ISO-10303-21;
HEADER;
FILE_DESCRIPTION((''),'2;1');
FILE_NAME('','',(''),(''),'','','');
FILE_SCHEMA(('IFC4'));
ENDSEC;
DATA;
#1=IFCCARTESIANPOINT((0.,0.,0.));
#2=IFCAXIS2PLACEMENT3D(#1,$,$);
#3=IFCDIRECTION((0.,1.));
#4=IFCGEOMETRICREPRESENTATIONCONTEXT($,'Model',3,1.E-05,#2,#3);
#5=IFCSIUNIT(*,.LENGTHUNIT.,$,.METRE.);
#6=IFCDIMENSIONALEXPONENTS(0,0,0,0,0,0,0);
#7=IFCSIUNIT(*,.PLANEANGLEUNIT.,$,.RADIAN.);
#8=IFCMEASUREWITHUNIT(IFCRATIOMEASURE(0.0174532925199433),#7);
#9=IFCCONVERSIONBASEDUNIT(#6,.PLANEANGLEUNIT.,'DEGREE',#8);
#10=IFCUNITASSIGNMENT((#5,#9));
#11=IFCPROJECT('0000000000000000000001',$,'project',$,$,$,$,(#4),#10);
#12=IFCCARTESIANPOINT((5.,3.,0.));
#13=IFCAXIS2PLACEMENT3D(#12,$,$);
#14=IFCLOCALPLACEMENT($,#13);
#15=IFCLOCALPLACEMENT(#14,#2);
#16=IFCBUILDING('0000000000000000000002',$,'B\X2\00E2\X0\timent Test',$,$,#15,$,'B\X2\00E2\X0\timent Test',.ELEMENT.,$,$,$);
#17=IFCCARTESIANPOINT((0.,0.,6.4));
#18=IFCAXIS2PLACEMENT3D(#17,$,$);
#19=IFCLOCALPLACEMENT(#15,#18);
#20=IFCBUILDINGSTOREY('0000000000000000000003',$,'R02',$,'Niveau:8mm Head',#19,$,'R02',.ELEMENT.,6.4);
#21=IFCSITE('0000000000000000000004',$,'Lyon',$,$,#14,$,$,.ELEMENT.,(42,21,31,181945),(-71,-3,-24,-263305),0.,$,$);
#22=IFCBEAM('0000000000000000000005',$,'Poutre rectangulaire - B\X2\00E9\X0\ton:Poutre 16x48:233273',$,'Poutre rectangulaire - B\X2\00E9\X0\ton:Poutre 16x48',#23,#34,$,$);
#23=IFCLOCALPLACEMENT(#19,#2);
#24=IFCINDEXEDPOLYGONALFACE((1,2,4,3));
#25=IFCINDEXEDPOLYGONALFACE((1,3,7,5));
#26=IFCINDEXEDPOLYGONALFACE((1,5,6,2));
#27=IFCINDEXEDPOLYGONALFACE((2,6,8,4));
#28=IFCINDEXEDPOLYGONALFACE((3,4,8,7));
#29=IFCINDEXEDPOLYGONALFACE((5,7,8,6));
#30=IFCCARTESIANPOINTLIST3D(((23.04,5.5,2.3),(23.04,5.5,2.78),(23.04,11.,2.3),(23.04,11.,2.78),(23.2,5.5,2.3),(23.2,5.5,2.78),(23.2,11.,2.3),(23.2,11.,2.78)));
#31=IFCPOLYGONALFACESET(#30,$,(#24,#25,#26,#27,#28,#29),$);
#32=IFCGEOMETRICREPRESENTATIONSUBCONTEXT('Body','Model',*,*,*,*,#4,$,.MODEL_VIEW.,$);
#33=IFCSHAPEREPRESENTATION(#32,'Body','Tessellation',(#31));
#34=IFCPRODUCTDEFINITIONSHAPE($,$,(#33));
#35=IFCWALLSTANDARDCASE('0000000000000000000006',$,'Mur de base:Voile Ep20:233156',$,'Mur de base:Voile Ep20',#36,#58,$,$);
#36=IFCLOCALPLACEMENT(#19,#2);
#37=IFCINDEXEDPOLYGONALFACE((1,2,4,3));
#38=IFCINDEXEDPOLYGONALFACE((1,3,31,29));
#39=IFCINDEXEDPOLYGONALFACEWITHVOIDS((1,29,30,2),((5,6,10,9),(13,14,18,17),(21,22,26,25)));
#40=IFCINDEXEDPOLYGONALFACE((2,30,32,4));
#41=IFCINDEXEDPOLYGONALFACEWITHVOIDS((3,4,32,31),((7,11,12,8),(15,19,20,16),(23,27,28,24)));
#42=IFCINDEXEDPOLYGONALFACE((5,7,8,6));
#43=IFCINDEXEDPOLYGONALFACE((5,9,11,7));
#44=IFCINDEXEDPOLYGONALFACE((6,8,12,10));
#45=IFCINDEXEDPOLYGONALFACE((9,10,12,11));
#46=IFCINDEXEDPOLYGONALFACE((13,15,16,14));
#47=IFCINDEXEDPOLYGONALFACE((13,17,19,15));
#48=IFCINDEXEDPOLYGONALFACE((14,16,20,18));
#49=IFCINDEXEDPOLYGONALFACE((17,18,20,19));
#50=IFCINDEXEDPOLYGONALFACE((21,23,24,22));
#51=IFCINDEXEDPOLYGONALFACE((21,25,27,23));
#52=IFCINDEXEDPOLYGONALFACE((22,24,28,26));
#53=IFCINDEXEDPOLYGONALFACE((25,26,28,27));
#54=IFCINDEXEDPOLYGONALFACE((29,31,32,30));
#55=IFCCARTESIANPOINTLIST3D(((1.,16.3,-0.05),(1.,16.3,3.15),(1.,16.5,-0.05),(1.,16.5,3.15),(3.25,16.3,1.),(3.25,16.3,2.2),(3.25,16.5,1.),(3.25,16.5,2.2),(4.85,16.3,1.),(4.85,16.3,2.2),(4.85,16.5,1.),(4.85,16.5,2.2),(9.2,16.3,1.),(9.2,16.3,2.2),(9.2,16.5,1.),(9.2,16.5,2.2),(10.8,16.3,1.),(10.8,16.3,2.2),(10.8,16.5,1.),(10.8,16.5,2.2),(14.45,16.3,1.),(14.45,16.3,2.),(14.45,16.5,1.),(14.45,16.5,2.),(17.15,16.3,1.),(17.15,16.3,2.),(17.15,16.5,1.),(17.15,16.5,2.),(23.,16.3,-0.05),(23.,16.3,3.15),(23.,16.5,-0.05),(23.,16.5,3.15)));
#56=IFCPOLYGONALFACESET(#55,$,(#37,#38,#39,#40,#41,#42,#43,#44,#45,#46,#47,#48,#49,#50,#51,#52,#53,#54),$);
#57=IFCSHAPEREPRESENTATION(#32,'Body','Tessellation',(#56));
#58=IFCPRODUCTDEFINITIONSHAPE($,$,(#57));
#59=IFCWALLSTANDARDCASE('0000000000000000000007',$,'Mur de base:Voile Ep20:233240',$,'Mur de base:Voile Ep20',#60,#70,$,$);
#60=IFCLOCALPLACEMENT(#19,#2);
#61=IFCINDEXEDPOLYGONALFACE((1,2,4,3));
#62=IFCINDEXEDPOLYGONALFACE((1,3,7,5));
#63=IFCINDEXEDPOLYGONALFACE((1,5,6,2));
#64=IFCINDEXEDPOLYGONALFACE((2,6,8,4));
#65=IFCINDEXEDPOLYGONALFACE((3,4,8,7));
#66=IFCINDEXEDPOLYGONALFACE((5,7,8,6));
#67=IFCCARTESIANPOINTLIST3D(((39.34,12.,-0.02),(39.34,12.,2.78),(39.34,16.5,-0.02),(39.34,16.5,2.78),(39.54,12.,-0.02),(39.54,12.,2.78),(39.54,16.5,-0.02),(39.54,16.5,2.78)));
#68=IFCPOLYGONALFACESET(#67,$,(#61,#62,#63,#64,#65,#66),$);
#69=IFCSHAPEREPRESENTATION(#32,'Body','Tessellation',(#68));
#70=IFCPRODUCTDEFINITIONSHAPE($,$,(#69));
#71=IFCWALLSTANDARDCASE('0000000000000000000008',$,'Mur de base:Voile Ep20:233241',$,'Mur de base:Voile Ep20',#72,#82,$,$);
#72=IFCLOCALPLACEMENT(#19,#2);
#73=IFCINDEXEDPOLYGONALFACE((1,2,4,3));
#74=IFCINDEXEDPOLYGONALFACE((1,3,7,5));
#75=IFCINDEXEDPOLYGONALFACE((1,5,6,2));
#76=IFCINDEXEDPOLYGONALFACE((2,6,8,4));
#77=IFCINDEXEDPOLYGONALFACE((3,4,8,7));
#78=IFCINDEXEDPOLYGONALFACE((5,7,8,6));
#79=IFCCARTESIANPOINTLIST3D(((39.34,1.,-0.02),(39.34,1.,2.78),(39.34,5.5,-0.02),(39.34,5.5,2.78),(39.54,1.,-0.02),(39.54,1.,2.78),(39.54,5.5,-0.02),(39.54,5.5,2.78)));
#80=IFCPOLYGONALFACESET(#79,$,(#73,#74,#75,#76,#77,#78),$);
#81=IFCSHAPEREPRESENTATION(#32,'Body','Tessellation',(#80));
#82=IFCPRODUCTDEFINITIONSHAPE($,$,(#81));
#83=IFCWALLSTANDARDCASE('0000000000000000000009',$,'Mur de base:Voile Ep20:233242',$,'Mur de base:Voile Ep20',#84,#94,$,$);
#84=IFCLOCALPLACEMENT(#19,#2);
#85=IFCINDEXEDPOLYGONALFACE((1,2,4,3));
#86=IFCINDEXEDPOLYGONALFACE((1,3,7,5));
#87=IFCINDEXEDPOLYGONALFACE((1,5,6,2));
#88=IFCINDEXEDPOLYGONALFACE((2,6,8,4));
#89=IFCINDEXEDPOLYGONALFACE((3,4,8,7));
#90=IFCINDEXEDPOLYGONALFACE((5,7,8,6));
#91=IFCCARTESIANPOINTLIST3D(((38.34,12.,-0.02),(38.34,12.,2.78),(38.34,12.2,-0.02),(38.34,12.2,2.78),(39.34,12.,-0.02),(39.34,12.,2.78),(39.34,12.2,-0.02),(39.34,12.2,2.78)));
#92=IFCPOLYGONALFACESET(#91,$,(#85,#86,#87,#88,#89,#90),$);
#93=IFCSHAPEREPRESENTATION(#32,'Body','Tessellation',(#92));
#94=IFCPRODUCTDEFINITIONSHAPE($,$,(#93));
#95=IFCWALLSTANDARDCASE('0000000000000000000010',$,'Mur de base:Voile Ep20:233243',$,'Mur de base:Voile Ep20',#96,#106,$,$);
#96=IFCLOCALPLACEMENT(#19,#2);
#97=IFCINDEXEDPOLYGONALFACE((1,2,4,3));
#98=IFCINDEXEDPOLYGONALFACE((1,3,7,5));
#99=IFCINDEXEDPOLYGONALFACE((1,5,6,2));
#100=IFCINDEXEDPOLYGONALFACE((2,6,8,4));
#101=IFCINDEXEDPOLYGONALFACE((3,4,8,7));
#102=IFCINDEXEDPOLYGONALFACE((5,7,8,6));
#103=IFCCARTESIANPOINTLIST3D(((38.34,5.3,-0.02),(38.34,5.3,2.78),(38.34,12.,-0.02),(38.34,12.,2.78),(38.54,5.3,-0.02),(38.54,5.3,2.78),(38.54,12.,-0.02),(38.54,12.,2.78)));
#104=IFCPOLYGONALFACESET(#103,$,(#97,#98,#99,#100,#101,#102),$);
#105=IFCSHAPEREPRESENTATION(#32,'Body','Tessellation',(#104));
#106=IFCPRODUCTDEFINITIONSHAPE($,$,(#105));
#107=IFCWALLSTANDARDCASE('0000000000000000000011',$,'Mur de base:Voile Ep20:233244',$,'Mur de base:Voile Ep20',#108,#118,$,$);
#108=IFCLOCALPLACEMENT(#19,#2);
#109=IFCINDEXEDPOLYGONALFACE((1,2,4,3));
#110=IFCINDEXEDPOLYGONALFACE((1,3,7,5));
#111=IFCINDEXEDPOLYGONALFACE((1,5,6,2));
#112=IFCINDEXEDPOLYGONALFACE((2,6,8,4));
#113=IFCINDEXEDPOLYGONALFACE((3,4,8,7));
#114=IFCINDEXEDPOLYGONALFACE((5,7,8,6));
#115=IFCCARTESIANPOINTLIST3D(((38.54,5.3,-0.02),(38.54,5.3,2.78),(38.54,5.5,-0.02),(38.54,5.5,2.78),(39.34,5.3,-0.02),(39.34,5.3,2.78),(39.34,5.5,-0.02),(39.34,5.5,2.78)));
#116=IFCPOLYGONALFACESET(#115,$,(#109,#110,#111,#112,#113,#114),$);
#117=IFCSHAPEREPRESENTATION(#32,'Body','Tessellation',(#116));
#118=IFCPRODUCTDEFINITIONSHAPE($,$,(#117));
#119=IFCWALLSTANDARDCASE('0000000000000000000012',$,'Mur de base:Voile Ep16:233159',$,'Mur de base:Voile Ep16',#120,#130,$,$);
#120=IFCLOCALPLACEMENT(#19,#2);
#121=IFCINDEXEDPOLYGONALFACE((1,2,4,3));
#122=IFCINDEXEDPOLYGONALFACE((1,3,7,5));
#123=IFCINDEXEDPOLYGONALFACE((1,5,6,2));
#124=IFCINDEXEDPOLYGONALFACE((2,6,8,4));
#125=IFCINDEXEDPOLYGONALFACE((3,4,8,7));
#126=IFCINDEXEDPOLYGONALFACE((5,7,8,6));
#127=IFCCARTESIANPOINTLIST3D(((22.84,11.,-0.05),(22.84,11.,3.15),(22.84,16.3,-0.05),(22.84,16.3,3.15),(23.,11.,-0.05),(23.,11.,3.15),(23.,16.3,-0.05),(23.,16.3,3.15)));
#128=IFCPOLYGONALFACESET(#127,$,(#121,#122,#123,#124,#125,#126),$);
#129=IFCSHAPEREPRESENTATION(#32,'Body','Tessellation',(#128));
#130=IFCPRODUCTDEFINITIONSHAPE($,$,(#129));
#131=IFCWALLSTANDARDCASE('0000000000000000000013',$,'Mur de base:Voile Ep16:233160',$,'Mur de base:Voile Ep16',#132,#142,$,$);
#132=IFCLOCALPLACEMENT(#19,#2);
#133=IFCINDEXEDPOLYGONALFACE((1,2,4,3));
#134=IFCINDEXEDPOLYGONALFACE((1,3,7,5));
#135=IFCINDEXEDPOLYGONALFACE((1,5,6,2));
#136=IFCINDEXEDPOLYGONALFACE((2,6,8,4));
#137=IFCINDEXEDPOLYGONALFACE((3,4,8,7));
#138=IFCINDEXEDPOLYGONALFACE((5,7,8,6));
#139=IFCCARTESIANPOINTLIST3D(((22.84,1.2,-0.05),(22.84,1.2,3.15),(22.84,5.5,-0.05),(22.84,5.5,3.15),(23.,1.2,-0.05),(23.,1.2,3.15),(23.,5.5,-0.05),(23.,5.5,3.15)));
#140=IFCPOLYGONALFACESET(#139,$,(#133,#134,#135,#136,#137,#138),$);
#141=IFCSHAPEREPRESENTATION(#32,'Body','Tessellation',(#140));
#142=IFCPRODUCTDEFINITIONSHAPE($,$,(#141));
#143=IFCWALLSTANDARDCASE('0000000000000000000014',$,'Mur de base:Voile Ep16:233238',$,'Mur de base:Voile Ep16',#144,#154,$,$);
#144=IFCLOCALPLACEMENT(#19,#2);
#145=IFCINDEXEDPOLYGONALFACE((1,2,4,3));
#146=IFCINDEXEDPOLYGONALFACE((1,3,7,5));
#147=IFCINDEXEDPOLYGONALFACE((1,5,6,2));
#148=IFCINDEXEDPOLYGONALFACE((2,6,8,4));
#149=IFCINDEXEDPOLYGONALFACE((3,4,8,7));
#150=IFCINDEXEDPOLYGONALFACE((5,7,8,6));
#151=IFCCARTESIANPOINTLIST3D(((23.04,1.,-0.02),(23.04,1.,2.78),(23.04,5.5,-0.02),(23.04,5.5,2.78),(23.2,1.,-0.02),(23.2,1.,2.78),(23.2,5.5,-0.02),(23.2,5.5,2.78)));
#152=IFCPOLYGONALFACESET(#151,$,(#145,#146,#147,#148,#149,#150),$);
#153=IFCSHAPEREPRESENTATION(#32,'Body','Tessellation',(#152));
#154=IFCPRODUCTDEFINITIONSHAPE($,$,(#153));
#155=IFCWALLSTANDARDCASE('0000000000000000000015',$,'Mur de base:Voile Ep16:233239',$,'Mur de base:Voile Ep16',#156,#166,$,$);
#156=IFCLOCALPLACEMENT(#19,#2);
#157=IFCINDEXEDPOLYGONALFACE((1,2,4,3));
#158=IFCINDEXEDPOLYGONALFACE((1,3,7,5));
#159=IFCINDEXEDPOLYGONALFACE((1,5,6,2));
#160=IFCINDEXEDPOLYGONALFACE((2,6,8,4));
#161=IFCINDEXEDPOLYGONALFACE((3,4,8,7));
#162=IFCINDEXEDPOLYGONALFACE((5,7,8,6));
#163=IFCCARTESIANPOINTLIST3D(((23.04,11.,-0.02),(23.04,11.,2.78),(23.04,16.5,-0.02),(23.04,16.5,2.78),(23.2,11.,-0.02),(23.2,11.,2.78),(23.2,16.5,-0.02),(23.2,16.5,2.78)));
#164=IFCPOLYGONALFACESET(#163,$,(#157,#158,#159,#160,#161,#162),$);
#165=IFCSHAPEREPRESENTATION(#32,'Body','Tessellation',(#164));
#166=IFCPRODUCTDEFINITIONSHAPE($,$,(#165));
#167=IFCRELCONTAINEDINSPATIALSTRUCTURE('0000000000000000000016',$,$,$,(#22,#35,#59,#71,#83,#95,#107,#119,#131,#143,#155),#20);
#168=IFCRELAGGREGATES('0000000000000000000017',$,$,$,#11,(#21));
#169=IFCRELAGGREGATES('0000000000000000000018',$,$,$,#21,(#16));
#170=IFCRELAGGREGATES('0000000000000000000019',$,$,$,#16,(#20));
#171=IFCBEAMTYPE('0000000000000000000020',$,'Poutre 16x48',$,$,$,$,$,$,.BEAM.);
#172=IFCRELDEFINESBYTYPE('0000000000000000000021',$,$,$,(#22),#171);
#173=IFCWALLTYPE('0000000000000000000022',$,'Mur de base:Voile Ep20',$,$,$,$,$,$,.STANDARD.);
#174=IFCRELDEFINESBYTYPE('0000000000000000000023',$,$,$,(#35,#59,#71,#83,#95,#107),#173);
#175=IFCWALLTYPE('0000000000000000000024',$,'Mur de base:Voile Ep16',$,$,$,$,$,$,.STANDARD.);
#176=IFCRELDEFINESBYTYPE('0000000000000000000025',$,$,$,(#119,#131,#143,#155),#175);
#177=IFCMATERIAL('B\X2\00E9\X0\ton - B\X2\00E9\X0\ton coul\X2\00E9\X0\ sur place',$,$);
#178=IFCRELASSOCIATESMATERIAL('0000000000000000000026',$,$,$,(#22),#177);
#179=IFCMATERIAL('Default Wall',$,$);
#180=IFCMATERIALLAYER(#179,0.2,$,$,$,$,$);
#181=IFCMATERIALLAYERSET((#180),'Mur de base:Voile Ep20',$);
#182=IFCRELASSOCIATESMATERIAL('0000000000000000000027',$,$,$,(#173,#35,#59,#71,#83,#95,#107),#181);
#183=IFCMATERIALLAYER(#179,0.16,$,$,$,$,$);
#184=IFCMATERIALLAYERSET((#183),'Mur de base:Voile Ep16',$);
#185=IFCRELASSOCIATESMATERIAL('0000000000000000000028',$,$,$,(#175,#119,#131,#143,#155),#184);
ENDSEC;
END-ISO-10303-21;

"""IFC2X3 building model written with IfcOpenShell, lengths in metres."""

from ifc_helpers import new_model, entity, si_unit, converted_unit, direction, frame, frame_2d, origin, origin_2d_with_axis, place, context, subcontext, project, spatial, rectangle, extrude, material, layer, layer_set, layer_usage, type_object, element, save


model = new_model("IFC2X3")

# Units and contexts
model_context = context("Model", 3, precision=1e-05, world=origin(), true_north=direction((0.0, 1.0)))
body_context = subcontext(model_context, "Body", "Model", "MODEL_VIEW")
ifc_project = project(units=[si_unit("LENGTHUNIT", "METRE"), converted_unit("PLANEANGLEUNIT", "DEGREE", entity("IfcRatioMeasure", 0.0174532925199433), si_unit("PLANEANGLEUNIT", "RADIAN"), dimensions=[0, 0, 0, 0, 0, 0, 0])], contexts=[model_context])

# Site, building, storey
site_placement = place(None, frame((5.0, 3.0, 0.0)))
site = spatial("IfcSite", under=ifc_project, at=site_placement, Name="Lyon", CompositionType="ELEMENT", RefLatitude=(42, 21, 31, 181945), RefLongitude=(-71, -3, -24, -263305), RefElevation=0.0)
building_placement = place(site_placement, origin())
building = spatial("IfcBuilding", under=site, at=building_placement, Name="Bâtiment Test", LongName="Bâtiment Test", CompositionType="ELEMENT")
storey_placement = place(building_placement, frame((0.0, 0.0, 6.4)))
storey = spatial("IfcBuildingStorey", under=building, at=storey_placement, Name="R02", ObjectType="Niveau:8mm Head", LongName="R02", CompositionType="ELEMENT", Elevation=6.4)

# Beam
ifc_material_1 = material(Name="Béton - Béton coulé sur place")
beam_type_1 = type_object("IfcBeamType", Name="Poutre 16x48", PredefinedType="BEAM")
beam_1_placement = place(storey_placement, frame((23.12, 11.0, 2.78), z_axis=(0.0, 0.0, 1.0), x_axis=(0.0, -1.0, 0.0)))
element("IfcBeam", 1, at=beam_1_placement, inside=storey, type_object=beam_type_1, material=ifc_material_1, Name="Poutre rectangulaire - Béton:Poutre 16x48:233273", ObjectType="Poutre rectangulaire - Béton:Poutre 16x48", context=body_context, shape_type="SweptSolid", body=[
    extrude(rectangle(XDim=0.48, YDim=0.16, at=frame_2d((0.0, 0.0), x_axis=(1.0, 0.0))), frame((0.0, 0.0, -0.24), z_axis=(1.0, 0.0, 0.0), x_axis=(0.0, 0.0, -1.0)), (0.0, 0.0, 1.0), 5.5),
])

# Wall, openings
ifc_material_2 = material(Name="Default Wall")
ifc_layer_1 = layer(ifc_material_2, 0.2)
ifc_layer_set_1 = layer_set([ifc_layer_1], Name="Mur de base:Voile Ep20")
ifc_layer_usage_1 = layer_usage(ifc_layer_set_1, "AXIS2", "POSITIVE", -0.1)
wall_type_1 = type_object("IfcWallType", Name="Mur de base:Voile Ep20", PredefinedType="STANDARD", material=ifc_layer_set_1)
wall_1_placement = place(storey_placement, frame((23.0, 16.4, -0.05), z_axis=(0.0, 0.0, 1.0), x_axis=(-1.0, 0.0, 0.0)))
wall_1 = element("IfcWallStandardCase", 2, at=wall_1_placement, inside=storey, type_object=wall_type_1, material=ifc_layer_usage_1, Name="Mur de base:Voile Ep20:233156", ObjectType="Mur de base:Voile Ep20", context=body_context, shape_type="SweptSolid", body=[
    extrude(rectangle(XDim=22.0, YDim=0.2, at=frame_2d((11.0, 0.0), x_axis=(-1.0, 0.0))), origin(), (0.0, 0.0, 1.0), 3.2),
])
opening_1_placement = place(wall_1_placement, origin())
element("IfcOpeningElement", 3, at=opening_1_placement, cuts=wall_1, ObjectType="Opening", context=body_context, shape_type="SweptSolid", body=[
    extrude(rectangle(XDim=1.0, YDim=2.7, at=frame_2d((0.0, 0.0), x_axis=(1.0, 0.0))), frame((7.2, -0.1, 1.55), z_axis=(0.0, 1.0, 0.0), x_axis=(0.0, 0.0, -1.0)), (0.0, 0.0, 1.0), 0.2),
])
opening_2_placement = place(wall_1_placement, origin())
element("IfcOpeningElement", 4, at=opening_2_placement, cuts=wall_1, ObjectType="Opening", context=body_context, shape_type="SweptSolid", body=[
    extrude(rectangle(XDim=1.2, YDim=1.6, at=origin_2d_with_axis()), frame((13.0, -0.1, 1.65), z_axis=(0.0, 1.0, 0.0), x_axis=(0.0, 0.0, -1.0)), (0.0, 0.0, 1.0), 0.2),
])
opening_3_placement = place(wall_1_placement, origin())
element("IfcOpeningElement", 5, at=opening_3_placement, cuts=wall_1, ObjectType="Opening", context=body_context, shape_type="SweptSolid", body=[
    extrude(rectangle(XDim=1.2, YDim=1.6, at=frame_2d((0.0, 0.0), x_axis=(1.0, 0.0))), frame((18.95, -0.1, 1.65), z_axis=(0.0, 1.0, 0.0), x_axis=(0.0, 0.0, -1.0)), (0.0, 0.0, 1.0), 0.2),
])

# Walls
ifc_layer_usage_2 = layer_usage(ifc_layer_set_1, "AXIS2", "NEGATIVE", 0.1)
wall_2_placement = place(storey_placement, frame((39.44, 16.5, -0.02), z_axis=(0.0, 0.0, 1.0), x_axis=(0.0, -1.0, 0.0)))
element("IfcWallStandardCase", 6, at=wall_2_placement, inside=storey, type_object=wall_type_1, material=ifc_layer_usage_2, Name="Mur de base:Voile Ep20:233240", ObjectType="Mur de base:Voile Ep20", context=body_context, shape_type="SweptSolid", body=[
    extrude(rectangle(XDim=4.5, YDim=0.2, at=frame_2d((2.25, 0.0), x_axis=(-1.0, 0.0))), origin(), (0.0, 0.0, 1.0), 2.8),
])
ifc_layer_usage_3 = layer_usage(ifc_layer_set_1, "AXIS2", "NEGATIVE", 0.1)
wall_3_placement = place(storey_placement, frame((39.44, 5.5, -0.02), z_axis=(0.0, 0.0, 1.0), x_axis=(0.0, -1.0, 0.0)))
element("IfcWallStandardCase", 7, at=wall_3_placement, inside=storey, type_object=wall_type_1, material=ifc_layer_usage_3, Name="Mur de base:Voile Ep20:233241", ObjectType="Mur de base:Voile Ep20", context=body_context, shape_type="SweptSolid", body=[
    extrude(rectangle(XDim=4.5, YDim=0.2, at=frame_2d((2.25, 0.0), x_axis=(-1.0, 0.0))), origin(), (0.0, 0.0, 1.0), 2.8),
])
ifc_layer_usage_4 = layer_usage(ifc_layer_set_1, "AXIS2", "NEGATIVE", 0.1)
wall_4_placement = place(storey_placement, frame((39.34, 12.1, -0.02), z_axis=(0.0, 0.0, 1.0), x_axis=(-1.0, 0.0, 0.0)))
element("IfcWallStandardCase", 8, at=wall_4_placement, inside=storey, type_object=wall_type_1, material=ifc_layer_usage_4, Name="Mur de base:Voile Ep20:233242", ObjectType="Mur de base:Voile Ep20", context=body_context, shape_type="SweptSolid", body=[
    extrude(rectangle(XDim=1.0, YDim=0.2, at=frame_2d((0.5, 0.0), x_axis=(-1.0, 0.0))), origin(), (0.0, 0.0, 1.0), 2.8),
])
ifc_layer_usage_5 = layer_usage(ifc_layer_set_1, "AXIS2", "NEGATIVE", 0.1)
wall_5_placement = place(storey_placement, frame((38.44, 12.0, -0.02), z_axis=(0.0, 0.0, 1.0), x_axis=(0.0, -1.0, 0.0)))
element("IfcWallStandardCase", 9, at=wall_5_placement, inside=storey, type_object=wall_type_1, material=ifc_layer_usage_5, Name="Mur de base:Voile Ep20:233243", ObjectType="Mur de base:Voile Ep20", context=body_context, shape_type="SweptSolid", body=[
    extrude(rectangle(XDim=6.7, YDim=0.2, at=frame_2d((3.35, 0.0), x_axis=(-1.0, 0.0))), origin(), (0.0, 0.0, 1.0), 2.8),
])
ifc_layer_usage_6 = layer_usage(ifc_layer_set_1, "AXIS2", "NEGATIVE", 0.1)
wall_6_placement = place(storey_placement, frame((38.54, 5.4, -0.02)))
element("IfcWallStandardCase", 10, at=wall_6_placement, inside=storey, type_object=wall_type_1, material=ifc_layer_usage_6, Name="Mur de base:Voile Ep20:233244", ObjectType="Mur de base:Voile Ep20", context=body_context, shape_type="SweptSolid", body=[
    extrude(rectangle(XDim=0.8, YDim=0.2, at=frame_2d((0.4, 0.0), x_axis=(-1.0, 0.0))), origin(), (0.0, 0.0, 1.0), 2.8),
])
ifc_layer_2 = layer(ifc_material_2, 0.16)
ifc_layer_set_2 = layer_set([ifc_layer_2], Name="Mur de base:Voile Ep16")
ifc_layer_usage_7 = layer_usage(ifc_layer_set_2, "AXIS2", "NEGATIVE", 0.08)
wall_type_2 = type_object("IfcWallType", Name="Mur de base:Voile Ep16", PredefinedType="STANDARD", material=ifc_layer_set_2)
wall_7_placement = place(storey_placement, frame((22.92, 16.3, -0.05), z_axis=(0.0, 0.0, 1.0), x_axis=(0.0, -1.0, 0.0)))
element("IfcWallStandardCase", 11, at=wall_7_placement, inside=storey, type_object=wall_type_2, material=ifc_layer_usage_7, Name="Mur de base:Voile Ep16:233159", ObjectType="Mur de base:Voile Ep16", context=body_context, shape_type="SweptSolid", body=[
    extrude(rectangle(XDim=5.3, YDim=0.16, at=frame_2d((2.65, 0.0), x_axis=(-1.0, 0.0))), origin(), (0.0, 0.0, 1.0), 3.2),
])
ifc_layer_usage_8 = layer_usage(ifc_layer_set_2, "AXIS2", "NEGATIVE", 0.08)
wall_8_placement = place(storey_placement, frame((22.92, 5.5, -0.05), z_axis=(0.0, 0.0, 1.0), x_axis=(0.0, -1.0, 0.0)))
element("IfcWallStandardCase", 12, at=wall_8_placement, inside=storey, type_object=wall_type_2, material=ifc_layer_usage_8, Name="Mur de base:Voile Ep16:233160", ObjectType="Mur de base:Voile Ep16", context=body_context, shape_type="SweptSolid", body=[
    extrude(rectangle(XDim=4.3, YDim=0.16, at=frame_2d((2.15, 0.0), x_axis=(-1.0, 0.0))), origin(), (0.0, 0.0, 1.0), 3.2),
])
ifc_layer_usage_9 = layer_usage(ifc_layer_set_2, "AXIS2", "NEGATIVE", 0.08)
wall_9_placement = place(storey_placement, frame((23.12, 1.0, -0.02), z_axis=(0.0, 0.0, 1.0), x_axis=(0.0, 1.0, 0.0)))
element("IfcWallStandardCase", 13, at=wall_9_placement, inside=storey, type_object=wall_type_2, material=ifc_layer_usage_9, Name="Mur de base:Voile Ep16:233238", ObjectType="Mur de base:Voile Ep16", context=body_context, shape_type="SweptSolid", body=[
    extrude(rectangle(XDim=4.5, YDim=0.16, at=frame_2d((2.25, 0.0), x_axis=(-1.0, 0.0))), origin(), (0.0, 0.0, 1.0), 2.8),
])
ifc_layer_usage_10 = layer_usage(ifc_layer_set_2, "AXIS2", "NEGATIVE", 0.08)
wall_10_placement = place(storey_placement, frame((23.12, 11.0, -0.02), z_axis=(0.0, 0.0, 1.0), x_axis=(0.0, 1.0, 0.0)))
element("IfcWallStandardCase", 14, at=wall_10_placement, inside=storey, type_object=wall_type_2, material=ifc_layer_usage_10, Name="Mur de base:Voile Ep16:233239", ObjectType="Mur de base:Voile Ep16", context=body_context, shape_type="SweptSolid", body=[
    extrude(rectangle(XDim=5.5, YDim=0.16, at=frame_2d((2.75, 0.0), x_axis=(-1.0, 0.0))), origin(), (0.0, 0.0, 1.0), 2.8),
])

save(model, "model.ifc")
